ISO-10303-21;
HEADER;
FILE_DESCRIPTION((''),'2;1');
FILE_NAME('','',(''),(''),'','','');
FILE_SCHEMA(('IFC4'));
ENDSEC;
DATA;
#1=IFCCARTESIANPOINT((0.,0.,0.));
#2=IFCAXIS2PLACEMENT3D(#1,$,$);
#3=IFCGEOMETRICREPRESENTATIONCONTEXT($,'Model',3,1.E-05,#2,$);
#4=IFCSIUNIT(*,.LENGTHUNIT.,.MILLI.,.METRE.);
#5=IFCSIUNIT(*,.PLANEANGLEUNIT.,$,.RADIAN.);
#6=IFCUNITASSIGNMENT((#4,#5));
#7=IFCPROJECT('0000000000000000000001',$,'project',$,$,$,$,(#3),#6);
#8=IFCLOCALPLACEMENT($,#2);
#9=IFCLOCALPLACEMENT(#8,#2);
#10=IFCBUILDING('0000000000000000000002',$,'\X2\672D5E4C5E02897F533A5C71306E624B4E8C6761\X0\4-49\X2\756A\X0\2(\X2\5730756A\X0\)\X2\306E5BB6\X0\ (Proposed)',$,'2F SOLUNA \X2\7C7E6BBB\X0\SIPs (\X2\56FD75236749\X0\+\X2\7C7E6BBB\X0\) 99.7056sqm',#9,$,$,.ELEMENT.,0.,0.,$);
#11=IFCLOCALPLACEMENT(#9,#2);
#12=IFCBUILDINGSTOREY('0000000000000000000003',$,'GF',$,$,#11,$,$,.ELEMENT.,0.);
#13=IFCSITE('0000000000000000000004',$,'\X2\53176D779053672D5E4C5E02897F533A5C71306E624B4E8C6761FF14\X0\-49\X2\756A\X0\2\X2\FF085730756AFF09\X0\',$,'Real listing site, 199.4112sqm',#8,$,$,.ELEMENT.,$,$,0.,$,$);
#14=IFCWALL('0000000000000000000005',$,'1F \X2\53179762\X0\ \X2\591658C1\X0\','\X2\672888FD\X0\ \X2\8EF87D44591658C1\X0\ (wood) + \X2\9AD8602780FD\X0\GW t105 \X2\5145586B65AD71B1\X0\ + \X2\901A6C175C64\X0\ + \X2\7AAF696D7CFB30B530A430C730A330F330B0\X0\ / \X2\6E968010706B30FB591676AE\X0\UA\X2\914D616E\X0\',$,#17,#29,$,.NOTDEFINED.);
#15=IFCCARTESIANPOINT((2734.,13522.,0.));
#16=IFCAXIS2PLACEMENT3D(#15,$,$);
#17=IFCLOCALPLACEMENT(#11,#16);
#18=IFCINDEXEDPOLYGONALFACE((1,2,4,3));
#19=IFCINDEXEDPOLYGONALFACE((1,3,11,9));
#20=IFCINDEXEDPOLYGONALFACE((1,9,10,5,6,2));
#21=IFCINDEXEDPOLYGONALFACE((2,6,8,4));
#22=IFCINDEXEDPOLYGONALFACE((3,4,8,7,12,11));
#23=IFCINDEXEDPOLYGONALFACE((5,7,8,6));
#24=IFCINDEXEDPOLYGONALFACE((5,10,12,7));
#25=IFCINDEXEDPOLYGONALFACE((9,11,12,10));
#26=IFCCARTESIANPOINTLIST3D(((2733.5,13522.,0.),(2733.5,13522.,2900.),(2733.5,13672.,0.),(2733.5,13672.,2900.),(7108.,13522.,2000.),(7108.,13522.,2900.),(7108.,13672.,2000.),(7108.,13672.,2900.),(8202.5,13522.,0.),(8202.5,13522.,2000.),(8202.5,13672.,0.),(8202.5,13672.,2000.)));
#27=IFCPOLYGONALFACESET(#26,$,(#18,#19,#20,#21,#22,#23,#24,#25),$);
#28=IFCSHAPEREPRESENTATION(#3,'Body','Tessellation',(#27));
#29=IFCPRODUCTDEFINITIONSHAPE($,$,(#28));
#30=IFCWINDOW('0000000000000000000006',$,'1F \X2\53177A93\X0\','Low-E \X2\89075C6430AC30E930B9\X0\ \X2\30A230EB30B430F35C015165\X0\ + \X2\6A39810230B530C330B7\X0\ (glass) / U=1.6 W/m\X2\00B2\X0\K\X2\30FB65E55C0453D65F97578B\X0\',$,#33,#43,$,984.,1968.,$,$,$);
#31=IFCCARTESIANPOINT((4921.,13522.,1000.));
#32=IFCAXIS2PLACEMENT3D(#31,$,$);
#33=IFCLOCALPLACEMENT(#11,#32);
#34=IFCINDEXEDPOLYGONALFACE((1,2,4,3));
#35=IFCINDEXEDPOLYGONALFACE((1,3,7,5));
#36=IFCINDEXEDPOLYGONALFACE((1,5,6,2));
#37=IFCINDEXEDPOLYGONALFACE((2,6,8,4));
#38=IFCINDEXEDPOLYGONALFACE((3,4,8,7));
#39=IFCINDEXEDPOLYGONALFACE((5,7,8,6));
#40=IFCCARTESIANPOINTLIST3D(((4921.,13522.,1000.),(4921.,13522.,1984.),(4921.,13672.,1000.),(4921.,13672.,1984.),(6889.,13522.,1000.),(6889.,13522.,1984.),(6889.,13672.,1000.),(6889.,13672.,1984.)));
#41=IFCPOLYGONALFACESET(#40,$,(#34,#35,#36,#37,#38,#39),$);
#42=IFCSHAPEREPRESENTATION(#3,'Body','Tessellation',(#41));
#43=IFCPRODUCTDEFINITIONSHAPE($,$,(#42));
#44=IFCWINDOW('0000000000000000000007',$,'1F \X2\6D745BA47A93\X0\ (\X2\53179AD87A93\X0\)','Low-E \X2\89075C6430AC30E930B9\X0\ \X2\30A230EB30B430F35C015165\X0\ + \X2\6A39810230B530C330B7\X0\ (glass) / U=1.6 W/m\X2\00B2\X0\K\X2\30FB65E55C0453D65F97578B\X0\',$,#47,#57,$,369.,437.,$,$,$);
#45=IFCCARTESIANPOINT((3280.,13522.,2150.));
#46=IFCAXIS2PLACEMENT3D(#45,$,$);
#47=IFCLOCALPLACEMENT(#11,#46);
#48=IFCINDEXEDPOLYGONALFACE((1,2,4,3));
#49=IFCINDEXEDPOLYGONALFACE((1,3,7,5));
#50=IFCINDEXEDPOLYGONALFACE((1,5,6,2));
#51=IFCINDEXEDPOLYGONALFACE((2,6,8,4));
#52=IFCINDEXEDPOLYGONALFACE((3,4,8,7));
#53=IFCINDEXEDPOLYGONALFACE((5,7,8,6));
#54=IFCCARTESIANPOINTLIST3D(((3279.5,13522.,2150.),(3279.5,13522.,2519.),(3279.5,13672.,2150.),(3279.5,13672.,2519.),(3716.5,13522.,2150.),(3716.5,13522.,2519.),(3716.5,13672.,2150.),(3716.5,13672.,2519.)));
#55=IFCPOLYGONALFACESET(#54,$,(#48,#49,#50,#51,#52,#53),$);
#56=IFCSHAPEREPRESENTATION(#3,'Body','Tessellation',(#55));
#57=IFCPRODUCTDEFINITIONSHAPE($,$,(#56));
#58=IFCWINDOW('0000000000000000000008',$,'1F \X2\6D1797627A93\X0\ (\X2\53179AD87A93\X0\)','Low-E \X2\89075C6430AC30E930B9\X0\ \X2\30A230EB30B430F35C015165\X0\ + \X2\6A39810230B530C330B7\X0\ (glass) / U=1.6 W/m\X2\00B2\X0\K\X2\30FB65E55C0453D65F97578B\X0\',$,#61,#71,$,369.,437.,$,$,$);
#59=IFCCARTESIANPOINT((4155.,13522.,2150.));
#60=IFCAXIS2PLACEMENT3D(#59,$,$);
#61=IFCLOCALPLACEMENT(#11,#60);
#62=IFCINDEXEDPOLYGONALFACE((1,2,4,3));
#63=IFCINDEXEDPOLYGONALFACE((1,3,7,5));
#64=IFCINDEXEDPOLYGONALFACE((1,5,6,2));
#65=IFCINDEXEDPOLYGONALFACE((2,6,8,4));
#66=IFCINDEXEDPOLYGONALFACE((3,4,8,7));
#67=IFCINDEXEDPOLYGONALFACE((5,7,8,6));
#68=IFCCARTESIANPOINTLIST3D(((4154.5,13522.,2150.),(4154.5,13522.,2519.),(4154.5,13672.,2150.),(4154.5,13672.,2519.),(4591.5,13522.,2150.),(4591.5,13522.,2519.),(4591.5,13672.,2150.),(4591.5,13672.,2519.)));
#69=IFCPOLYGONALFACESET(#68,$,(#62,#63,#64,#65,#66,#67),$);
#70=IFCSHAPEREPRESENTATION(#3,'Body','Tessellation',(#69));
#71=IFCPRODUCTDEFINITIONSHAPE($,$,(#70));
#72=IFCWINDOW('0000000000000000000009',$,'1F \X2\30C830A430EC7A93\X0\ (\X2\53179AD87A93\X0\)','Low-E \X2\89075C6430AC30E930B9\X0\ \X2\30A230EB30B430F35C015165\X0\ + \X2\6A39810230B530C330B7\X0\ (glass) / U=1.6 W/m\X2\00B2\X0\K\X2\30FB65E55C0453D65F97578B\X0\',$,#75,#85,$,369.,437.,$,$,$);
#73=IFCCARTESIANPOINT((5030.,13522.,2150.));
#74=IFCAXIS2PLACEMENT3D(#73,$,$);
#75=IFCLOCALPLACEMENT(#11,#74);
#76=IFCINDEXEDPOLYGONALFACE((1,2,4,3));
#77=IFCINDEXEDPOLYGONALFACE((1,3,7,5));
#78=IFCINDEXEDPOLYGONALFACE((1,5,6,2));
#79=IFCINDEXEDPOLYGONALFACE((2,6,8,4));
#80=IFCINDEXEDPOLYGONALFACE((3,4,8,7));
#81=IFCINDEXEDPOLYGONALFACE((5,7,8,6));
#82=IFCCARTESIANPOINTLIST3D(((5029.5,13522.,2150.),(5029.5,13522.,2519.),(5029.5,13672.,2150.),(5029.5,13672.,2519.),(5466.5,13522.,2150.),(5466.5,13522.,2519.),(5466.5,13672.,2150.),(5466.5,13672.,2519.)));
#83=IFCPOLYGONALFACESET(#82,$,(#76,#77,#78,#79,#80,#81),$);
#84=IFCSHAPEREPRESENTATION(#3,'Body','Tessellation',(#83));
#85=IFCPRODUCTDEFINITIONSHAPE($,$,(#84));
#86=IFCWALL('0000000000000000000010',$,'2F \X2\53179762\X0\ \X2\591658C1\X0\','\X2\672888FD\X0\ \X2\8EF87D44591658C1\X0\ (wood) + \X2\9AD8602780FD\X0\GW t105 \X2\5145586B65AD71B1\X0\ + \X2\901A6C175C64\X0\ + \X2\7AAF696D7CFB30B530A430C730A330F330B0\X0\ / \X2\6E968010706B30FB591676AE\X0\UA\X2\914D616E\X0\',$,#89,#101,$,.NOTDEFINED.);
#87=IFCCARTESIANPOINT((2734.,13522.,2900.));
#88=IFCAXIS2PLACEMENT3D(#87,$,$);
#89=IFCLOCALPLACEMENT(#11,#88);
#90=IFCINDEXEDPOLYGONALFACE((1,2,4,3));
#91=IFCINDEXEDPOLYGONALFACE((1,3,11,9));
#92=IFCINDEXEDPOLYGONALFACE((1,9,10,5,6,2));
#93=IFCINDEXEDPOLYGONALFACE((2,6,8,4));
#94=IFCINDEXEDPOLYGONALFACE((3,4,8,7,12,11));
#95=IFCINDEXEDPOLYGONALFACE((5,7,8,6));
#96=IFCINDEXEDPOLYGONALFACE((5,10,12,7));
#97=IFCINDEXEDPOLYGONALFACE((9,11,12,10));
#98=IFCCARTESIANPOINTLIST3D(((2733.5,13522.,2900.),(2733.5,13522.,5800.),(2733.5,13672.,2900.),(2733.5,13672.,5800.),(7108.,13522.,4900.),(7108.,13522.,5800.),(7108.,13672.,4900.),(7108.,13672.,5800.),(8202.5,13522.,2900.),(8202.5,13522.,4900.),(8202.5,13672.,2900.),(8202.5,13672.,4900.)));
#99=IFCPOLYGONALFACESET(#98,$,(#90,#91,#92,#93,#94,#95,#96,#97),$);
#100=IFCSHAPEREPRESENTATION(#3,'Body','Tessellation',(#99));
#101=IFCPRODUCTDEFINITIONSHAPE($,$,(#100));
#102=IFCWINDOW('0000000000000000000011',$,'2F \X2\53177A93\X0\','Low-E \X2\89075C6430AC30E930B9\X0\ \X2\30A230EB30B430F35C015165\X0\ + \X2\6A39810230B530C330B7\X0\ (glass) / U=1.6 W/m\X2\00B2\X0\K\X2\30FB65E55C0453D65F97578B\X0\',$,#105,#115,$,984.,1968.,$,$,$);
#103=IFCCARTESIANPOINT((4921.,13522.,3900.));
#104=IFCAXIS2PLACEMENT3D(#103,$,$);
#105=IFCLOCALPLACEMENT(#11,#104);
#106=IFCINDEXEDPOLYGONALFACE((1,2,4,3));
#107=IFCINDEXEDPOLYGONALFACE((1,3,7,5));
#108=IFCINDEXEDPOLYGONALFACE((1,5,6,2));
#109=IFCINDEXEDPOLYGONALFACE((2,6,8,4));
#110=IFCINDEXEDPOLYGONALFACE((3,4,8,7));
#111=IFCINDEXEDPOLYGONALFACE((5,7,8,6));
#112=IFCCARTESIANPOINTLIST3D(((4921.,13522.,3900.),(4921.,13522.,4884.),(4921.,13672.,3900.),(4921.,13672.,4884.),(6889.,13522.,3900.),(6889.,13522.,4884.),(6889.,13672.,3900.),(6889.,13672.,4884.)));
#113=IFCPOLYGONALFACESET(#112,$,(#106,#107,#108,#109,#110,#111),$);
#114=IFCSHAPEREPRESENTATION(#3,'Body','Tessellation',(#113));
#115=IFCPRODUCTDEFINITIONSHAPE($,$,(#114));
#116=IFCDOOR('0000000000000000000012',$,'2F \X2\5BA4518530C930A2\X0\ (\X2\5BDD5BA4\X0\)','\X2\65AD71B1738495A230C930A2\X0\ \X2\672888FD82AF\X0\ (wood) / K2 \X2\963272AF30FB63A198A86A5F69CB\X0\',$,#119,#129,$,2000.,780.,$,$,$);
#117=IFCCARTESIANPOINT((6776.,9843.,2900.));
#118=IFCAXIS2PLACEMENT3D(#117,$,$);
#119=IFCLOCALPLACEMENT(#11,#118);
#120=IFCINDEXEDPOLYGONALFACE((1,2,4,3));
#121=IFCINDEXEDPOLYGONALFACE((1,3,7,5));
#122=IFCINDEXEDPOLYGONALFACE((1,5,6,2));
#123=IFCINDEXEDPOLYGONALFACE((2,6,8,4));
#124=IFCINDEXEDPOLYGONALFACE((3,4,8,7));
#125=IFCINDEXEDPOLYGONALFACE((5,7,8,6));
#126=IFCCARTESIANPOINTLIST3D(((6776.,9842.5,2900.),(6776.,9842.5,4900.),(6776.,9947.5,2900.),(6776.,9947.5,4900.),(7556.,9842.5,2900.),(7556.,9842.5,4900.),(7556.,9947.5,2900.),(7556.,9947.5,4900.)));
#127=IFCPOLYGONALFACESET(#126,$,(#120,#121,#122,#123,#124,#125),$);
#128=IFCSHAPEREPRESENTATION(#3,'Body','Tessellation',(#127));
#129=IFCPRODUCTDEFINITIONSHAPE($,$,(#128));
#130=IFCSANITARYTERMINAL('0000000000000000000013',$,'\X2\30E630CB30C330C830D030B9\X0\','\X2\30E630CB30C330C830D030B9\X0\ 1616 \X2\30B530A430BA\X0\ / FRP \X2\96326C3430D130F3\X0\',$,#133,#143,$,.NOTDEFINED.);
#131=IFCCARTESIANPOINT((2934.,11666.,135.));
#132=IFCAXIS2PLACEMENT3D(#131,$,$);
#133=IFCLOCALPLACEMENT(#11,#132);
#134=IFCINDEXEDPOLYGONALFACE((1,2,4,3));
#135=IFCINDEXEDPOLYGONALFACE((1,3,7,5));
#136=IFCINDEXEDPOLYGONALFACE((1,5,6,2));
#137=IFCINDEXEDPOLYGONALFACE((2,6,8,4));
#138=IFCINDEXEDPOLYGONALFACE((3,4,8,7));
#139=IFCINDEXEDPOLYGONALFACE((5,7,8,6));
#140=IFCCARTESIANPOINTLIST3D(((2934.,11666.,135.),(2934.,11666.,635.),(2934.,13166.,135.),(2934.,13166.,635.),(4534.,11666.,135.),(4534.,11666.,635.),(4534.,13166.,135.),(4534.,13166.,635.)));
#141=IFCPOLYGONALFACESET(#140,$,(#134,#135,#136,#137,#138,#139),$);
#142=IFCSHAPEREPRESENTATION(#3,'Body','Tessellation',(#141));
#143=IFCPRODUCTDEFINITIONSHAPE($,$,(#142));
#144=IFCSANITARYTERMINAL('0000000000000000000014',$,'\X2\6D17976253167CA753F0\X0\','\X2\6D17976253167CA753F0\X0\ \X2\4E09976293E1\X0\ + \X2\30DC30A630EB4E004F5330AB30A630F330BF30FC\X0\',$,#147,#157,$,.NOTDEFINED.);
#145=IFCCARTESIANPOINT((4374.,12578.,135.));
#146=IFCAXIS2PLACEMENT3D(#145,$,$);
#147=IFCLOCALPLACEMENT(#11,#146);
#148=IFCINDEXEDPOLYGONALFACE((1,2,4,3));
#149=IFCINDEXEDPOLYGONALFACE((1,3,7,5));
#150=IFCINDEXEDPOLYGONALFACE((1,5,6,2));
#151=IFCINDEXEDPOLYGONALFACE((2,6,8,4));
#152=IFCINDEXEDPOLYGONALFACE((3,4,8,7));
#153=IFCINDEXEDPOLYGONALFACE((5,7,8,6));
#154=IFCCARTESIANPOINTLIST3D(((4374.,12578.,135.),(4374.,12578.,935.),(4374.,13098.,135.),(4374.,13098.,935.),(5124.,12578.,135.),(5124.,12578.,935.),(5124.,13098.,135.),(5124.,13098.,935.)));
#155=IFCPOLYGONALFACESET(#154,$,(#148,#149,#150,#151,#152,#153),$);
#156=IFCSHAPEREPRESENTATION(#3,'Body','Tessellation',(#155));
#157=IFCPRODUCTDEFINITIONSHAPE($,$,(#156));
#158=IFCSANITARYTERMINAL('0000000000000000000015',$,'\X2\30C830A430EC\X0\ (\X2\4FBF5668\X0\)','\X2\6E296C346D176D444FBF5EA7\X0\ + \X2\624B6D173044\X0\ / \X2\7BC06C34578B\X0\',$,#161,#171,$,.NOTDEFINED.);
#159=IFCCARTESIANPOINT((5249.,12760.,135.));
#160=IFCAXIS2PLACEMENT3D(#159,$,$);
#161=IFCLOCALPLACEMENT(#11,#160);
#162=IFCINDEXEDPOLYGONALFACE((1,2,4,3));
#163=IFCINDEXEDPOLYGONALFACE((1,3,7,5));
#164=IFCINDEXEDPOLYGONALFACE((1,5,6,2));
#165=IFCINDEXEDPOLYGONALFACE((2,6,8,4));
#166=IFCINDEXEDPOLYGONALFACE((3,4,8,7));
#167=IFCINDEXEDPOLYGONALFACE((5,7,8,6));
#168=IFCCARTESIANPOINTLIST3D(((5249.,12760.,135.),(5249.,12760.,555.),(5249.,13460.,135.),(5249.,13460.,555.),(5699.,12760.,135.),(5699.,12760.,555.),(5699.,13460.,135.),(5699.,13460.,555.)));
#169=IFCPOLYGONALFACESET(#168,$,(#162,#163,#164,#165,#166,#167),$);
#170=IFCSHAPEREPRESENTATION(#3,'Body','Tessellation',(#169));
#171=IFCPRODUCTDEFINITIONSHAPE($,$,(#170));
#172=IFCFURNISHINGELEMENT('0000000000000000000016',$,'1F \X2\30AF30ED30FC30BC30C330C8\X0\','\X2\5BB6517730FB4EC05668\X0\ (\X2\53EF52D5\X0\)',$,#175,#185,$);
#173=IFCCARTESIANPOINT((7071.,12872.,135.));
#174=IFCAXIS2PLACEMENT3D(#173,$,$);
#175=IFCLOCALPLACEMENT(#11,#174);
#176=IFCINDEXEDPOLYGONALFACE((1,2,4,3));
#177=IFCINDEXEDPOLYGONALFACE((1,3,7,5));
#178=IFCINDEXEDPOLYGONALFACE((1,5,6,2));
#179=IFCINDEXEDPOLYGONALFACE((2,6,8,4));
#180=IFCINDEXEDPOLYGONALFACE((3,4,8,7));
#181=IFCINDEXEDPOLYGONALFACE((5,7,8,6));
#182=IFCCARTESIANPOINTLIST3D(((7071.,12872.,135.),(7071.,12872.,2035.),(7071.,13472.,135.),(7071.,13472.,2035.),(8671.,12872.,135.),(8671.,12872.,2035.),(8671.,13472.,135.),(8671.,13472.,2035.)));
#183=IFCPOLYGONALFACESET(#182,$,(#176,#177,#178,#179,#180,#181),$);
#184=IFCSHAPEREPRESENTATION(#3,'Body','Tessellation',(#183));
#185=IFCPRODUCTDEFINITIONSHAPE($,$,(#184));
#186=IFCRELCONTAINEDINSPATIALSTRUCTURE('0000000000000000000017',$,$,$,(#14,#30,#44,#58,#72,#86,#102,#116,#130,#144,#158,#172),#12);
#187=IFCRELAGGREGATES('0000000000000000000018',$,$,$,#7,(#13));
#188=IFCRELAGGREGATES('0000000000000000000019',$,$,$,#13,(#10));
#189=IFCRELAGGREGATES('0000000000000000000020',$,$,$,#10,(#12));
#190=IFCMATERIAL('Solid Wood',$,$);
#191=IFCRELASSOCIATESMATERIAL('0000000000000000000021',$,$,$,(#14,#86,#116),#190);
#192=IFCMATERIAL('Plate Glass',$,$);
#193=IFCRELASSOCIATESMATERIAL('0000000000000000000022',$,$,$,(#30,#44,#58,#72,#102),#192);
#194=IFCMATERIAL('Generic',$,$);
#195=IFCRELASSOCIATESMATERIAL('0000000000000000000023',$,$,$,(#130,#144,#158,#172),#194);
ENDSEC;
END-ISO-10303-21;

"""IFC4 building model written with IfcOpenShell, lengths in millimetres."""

from ifc_helpers import new_model, si_unit, frame, frame_2d, origin, place, context, project, spatial, rectangle, extrude, material, element, fill, save


model = new_model("IFC4")

# Units and contexts
model_context = context("Model", 3, precision=1e-05, world=origin())
ifc_project = project(units=[si_unit("LENGTHUNIT", "METRE", prefix="MILLI"), si_unit("PLANEANGLEUNIT", "RADIAN")], contexts=[model_context])

# Site, building, storey
site_placement = place(None, origin())
site = spatial("IfcSite", under=ifc_project, at=site_placement, Name="北海道札幌市西区山の手二条４-49番2（地番）", ObjectType="Real listing site, 199.4112sqm", CompositionType="ELEMENT", RefElevation=0.0)
building_placement = place(site_placement, origin())
building = spatial("IfcBuilding", under=site, at=building_placement, Name="札幌市西区山の手二条4-49番2(地番)の家 (Proposed)", ObjectType="2F SOLUNA 籾殻SIPs (国産杉+籾殻) 99.7056sqm", CompositionType="ELEMENT", ElevationOfRefHeight=0.0, ElevationOfTerrain=0.0)
storey_placement = place(building_placement, origin())
storey = spatial("IfcBuildingStorey", under=building, at=storey_placement, Name="GF", CompositionType="ELEMENT", Elevation=0.0)

# Wall, openings, windows
ifc_material_1 = material(Name="Solid Wood")
wall_1_placement = place(storey_placement, frame((2734.0, 13522.0, 0.0)))
wall_1 = element("IfcWall", 1, at=wall_1_placement, inside=storey, material=ifc_material_1, Name="1F 北面 外壁", Description="木製 軸組外壁 (wood) + 高性能GW t105 充填断熱 + 通気層 + 窯業系サイディング / 準耐火・外皮UA配慮", PredefinedType="NOTDEFINED", context=model_context, shape_type="SweptSolid", body=[
    extrude(rectangle(XDim=5469.0, YDim=150.0, at=frame_2d((2734.0, 75.0))), frame((2734.0, 13522.0, 0.0)), (0.0, 0.0, 1.0), 2900.0),
])
opening_1_placement = place(storey_placement, frame((4921.0, 13522.0, 1000.0)))
opening_1 = element("IfcOpeningElement", 2, at=opening_1_placement, cuts=wall_1, PredefinedType="NOTDEFINED", context=model_context, shape_type="SweptSolid", body=[
    extrude(rectangle(XDim=1968.0, YDim=150.0, at=frame_2d((984.0, 75.0))), frame((4921.0, 13522.0, 1000.0)), (0.0, 0.0, 1.0), 984.0),
])
opening_2_placement = place(storey_placement, frame((3280.0, 13522.0, 2150.0)))
opening_2 = element("IfcOpeningElement", 3, at=opening_2_placement, cuts=wall_1, PredefinedType="NOTDEFINED", context=model_context, shape_type="SweptSolid", body=[
    extrude(rectangle(XDim=437.0, YDim=150.0, at=frame_2d((218.0, 75.0))), frame((3280.0, 13522.0, 2150.0)), (0.0, 0.0, 1.0), 369.0),
])
opening_3_placement = place(storey_placement, frame((4155.0, 13522.0, 2150.0)))
opening_3 = element("IfcOpeningElement", 4, at=opening_3_placement, cuts=wall_1, PredefinedType="NOTDEFINED", context=model_context, shape_type="SweptSolid", body=[
    extrude(rectangle(XDim=437.0, YDim=150.0, at=frame_2d((218.0, 75.0))), frame((4155.0, 13522.0, 2150.0)), (0.0, 0.0, 1.0), 369.0),
])
opening_4_placement = place(storey_placement, frame((5030.0, 13522.0, 2150.0)))
opening_4 = element("IfcOpeningElement", 5, at=opening_4_placement, cuts=wall_1, PredefinedType="NOTDEFINED", context=model_context, shape_type="SweptSolid", body=[
    extrude(rectangle(XDim=437.0, YDim=150.0, at=frame_2d((218.0, 75.0))), frame((5030.0, 13522.0, 2150.0)), (0.0, 0.0, 1.0), 369.0),
])
ifc_material_2 = material(Name="Plate Glass")
window_1_placement = place(storey_placement, frame((4921.0, 13522.0, 1000.0)))
window_1 = element("IfcWindow", 6, at=window_1_placement, inside=storey, material=ifc_material_2, Name="1F 北窓", Description="Low-E 複層ガラス アルゴン封入 + 樹脂サッシ (glass) / U=1.6 W/m²K・日射取得型", OverallHeight=984.0, OverallWidth=1968.0, context=model_context, shape_type="SweptSolid", body=[
    extrude(rectangle(XDim=1968.0, YDim=150.0, at=frame_2d((984.0, 75.0))), frame((4921.0, 13522.0, 1000.0)), (0.0, 0.0, 1.0), 984.0),
])
fill(opening_1, window_1)
window_2_placement = place(storey_placement, frame((3280.0, 13522.0, 2150.0)))
window_2 = element("IfcWindow", 7, at=window_2_placement, inside=storey, material=ifc_material_2, Name="1F 浴室窓 (北高窓)", Description="Low-E 複層ガラス アルゴン封入 + 樹脂サッシ (glass) / U=1.6 W/m²K・日射取得型", OverallHeight=369.0, OverallWidth=437.0, context=model_context, shape_type="SweptSolid", body=[
    extrude(rectangle(XDim=437.0, YDim=150.0, at=frame_2d((218.0, 75.0))), frame((3280.0, 13522.0, 2150.0)), (0.0, 0.0, 1.0), 369.0),
])
fill(opening_2, window_2)
window_3_placement = place(storey_placement, frame((4155.0, 13522.0, 2150.0)))
window_3 = element("IfcWindow", 8, at=window_3_placement, inside=storey, material=ifc_material_2, Name="1F 洗面窓 (北高窓)", Description="Low-E 複層ガラス アルゴン封入 + 樹脂サッシ (glass) / U=1.6 W/m²K・日射取得型", OverallHeight=369.0, OverallWidth=437.0, context=model_context, shape_type="SweptSolid", body=[
    extrude(rectangle(XDim=437.0, YDim=150.0, at=frame_2d((218.0, 75.0))), frame((4155.0, 13522.0, 2150.0)), (0.0, 0.0, 1.0), 369.0),
])
fill(opening_3, window_3)
window_4_placement = place(storey_placement, frame((5030.0, 13522.0, 2150.0)))
window_4 = element("IfcWindow", 9, at=window_4_placement, inside=storey, material=ifc_material_2, Name="1F トイレ窓 (北高窓)", Description="Low-E 複層ガラス アルゴン封入 + 樹脂サッシ (glass) / U=1.6 W/m²K・日射取得型", OverallHeight=369.0, OverallWidth=437.0, context=model_context, shape_type="SweptSolid", body=[
    extrude(rectangle(XDim=437.0, YDim=150.0, at=frame_2d((218.0, 75.0))), frame((5030.0, 13522.0, 2150.0)), (0.0, 0.0, 1.0), 369.0),
])
fill(opening_4, window_4)

# Wall, opening, window
wall_2_placement = place(storey_placement, frame((2734.0, 13522.0, 2900.0)))
wall_2 = element("IfcWall", 10, at=wall_2_placement, inside=storey, material=ifc_material_1, Name="2F 北面 外壁", Description="木製 軸組外壁 (wood) + 高性能GW t105 充填断熱 + 通気層 + 窯業系サイディング / 準耐火・外皮UA配慮", PredefinedType="NOTDEFINED", context=model_context, shape_type="SweptSolid", body=[
    extrude(rectangle(XDim=5469.0, YDim=150.0, at=frame_2d((2734.0, 75.0))), frame((2734.0, 13522.0, 2900.0)), (0.0, 0.0, 1.0), 2900.0),
])
opening_5_placement = place(storey_placement, frame((4921.0, 13522.0, 3900.0)))
opening_5 = element("IfcOpeningElement", 11, at=opening_5_placement, cuts=wall_2, PredefinedType="NOTDEFINED", context=model_context, shape_type="SweptSolid", body=[
    extrude(rectangle(XDim=1968.0, YDim=150.0, at=frame_2d((984.0, 75.0))), frame((4921.0, 13522.0, 3900.0)), (0.0, 0.0, 1.0), 984.0),
])
window_5_placement = place(storey_placement, frame((4921.0, 13522.0, 3900.0)))
window_5 = element("IfcWindow", 12, at=window_5_placement, inside=storey, material=ifc_material_2, Name="2F 北窓", Description="Low-E 複層ガラス アルゴン封入 + 樹脂サッシ (glass) / U=1.6 W/m²K・日射取得型", OverallHeight=984.0, OverallWidth=1968.0, context=model_context, shape_type="SweptSolid", body=[
    extrude(rectangle(XDim=1968.0, YDim=150.0, at=frame_2d((984.0, 75.0))), frame((4921.0, 13522.0, 3900.0)), (0.0, 0.0, 1.0), 984.0),
])
fill(opening_5, window_5)

# Door
door_1_placement = place(storey_placement, frame((6776.0, 9843.0, 2900.0)))
element("IfcDoor", 13, at=door_1_placement, inside=storey, material=ifc_material_1, Name="2F 室内ドア (寝室)", Description="断熱玄関ドア 木製芯 (wood) / K2 防犯・採風機構", OverallHeight=2000.0, OverallWidth=780.0, context=model_context, shape_type="SweptSolid", body=[
    extrude(rectangle(XDim=780.0, YDim=105.0, at=frame_2d((390.0, 52.0))), frame((6776.0, 9843.0, 2900.0)), (0.0, 0.0, 1.0), 2000.0),
])

# Sanitary terminals
ifc_material_3 = material(Name="Generic")
sanitary_terminal_1_placement = place(storey_placement, frame((2934.0, 11666.0, 135.0)))
element("IfcSanitaryTerminal", 14, at=sanitary_terminal_1_placement, inside=storey, material=ifc_material_3, Name="ユニットバス", Description="ユニットバス 1616 サイズ / FRP 防水パン", PredefinedType="NOTDEFINED", context=model_context, shape_type="SweptSolid", body=[
    extrude(rectangle(XDim=1600.0, YDim=1500.0, at=frame_2d((800.0, 750.0))), frame((2934.0, 11666.0, 135.0)), (0.0, 0.0, 1.0), 500.0),
])
sanitary_terminal_2_placement = place(storey_placement, frame((4374.0, 12578.0, 135.0)))
element("IfcSanitaryTerminal", 15, at=sanitary_terminal_2_placement, inside=storey, material=ifc_material_3, Name="洗面化粧台", Description="洗面化粧台 三面鏡 + ボウル一体カウンター", PredefinedType="NOTDEFINED", context=model_context, shape_type="SweptSolid", body=[
    extrude(rectangle(XDim=750.0, YDim=520.0, at=frame_2d((375.0, 260.0))), frame((4374.0, 12578.0, 135.0)), (0.0, 0.0, 1.0), 800.0),
])
sanitary_terminal_3_placement = place(storey_placement, frame((5249.0, 12760.0, 135.0)))
element("IfcSanitaryTerminal", 16, at=sanitary_terminal_3_placement, inside=storey, material=ifc_material_3, Name="トイレ (便器)", Description="温水洗浄便座 + 手洗い / 節水型", PredefinedType="NOTDEFINED", context=model_context, shape_type="SweptSolid", body=[
    extrude(rectangle(XDim=450.0, YDim=700.0, at=frame_2d((225.0, 350.0))), frame((5249.0, 12760.0, 135.0)), (0.0, 0.0, 1.0), 420.0),
])

# Furnishing element
furnishing_1_placement = place(storey_placement, frame((7071.0, 12872.0, 135.0)))
element("IfcFurnishingElement", 17, at=furnishing_1_placement, inside=storey, material=ifc_material_3, Name="1F クローゼット", Description="家具・什器 (可動)", context=model_context, shape_type="SweptSolid", body=[
    extrude(rectangle(XDim=1600.0, YDim=600.0, at=frame_2d((800.0, 300.0))), frame((7071.0, 12872.0, 135.0)), (0.0, 0.0, 1.0), 1900.0),
])

save(model, "model.ifc")
